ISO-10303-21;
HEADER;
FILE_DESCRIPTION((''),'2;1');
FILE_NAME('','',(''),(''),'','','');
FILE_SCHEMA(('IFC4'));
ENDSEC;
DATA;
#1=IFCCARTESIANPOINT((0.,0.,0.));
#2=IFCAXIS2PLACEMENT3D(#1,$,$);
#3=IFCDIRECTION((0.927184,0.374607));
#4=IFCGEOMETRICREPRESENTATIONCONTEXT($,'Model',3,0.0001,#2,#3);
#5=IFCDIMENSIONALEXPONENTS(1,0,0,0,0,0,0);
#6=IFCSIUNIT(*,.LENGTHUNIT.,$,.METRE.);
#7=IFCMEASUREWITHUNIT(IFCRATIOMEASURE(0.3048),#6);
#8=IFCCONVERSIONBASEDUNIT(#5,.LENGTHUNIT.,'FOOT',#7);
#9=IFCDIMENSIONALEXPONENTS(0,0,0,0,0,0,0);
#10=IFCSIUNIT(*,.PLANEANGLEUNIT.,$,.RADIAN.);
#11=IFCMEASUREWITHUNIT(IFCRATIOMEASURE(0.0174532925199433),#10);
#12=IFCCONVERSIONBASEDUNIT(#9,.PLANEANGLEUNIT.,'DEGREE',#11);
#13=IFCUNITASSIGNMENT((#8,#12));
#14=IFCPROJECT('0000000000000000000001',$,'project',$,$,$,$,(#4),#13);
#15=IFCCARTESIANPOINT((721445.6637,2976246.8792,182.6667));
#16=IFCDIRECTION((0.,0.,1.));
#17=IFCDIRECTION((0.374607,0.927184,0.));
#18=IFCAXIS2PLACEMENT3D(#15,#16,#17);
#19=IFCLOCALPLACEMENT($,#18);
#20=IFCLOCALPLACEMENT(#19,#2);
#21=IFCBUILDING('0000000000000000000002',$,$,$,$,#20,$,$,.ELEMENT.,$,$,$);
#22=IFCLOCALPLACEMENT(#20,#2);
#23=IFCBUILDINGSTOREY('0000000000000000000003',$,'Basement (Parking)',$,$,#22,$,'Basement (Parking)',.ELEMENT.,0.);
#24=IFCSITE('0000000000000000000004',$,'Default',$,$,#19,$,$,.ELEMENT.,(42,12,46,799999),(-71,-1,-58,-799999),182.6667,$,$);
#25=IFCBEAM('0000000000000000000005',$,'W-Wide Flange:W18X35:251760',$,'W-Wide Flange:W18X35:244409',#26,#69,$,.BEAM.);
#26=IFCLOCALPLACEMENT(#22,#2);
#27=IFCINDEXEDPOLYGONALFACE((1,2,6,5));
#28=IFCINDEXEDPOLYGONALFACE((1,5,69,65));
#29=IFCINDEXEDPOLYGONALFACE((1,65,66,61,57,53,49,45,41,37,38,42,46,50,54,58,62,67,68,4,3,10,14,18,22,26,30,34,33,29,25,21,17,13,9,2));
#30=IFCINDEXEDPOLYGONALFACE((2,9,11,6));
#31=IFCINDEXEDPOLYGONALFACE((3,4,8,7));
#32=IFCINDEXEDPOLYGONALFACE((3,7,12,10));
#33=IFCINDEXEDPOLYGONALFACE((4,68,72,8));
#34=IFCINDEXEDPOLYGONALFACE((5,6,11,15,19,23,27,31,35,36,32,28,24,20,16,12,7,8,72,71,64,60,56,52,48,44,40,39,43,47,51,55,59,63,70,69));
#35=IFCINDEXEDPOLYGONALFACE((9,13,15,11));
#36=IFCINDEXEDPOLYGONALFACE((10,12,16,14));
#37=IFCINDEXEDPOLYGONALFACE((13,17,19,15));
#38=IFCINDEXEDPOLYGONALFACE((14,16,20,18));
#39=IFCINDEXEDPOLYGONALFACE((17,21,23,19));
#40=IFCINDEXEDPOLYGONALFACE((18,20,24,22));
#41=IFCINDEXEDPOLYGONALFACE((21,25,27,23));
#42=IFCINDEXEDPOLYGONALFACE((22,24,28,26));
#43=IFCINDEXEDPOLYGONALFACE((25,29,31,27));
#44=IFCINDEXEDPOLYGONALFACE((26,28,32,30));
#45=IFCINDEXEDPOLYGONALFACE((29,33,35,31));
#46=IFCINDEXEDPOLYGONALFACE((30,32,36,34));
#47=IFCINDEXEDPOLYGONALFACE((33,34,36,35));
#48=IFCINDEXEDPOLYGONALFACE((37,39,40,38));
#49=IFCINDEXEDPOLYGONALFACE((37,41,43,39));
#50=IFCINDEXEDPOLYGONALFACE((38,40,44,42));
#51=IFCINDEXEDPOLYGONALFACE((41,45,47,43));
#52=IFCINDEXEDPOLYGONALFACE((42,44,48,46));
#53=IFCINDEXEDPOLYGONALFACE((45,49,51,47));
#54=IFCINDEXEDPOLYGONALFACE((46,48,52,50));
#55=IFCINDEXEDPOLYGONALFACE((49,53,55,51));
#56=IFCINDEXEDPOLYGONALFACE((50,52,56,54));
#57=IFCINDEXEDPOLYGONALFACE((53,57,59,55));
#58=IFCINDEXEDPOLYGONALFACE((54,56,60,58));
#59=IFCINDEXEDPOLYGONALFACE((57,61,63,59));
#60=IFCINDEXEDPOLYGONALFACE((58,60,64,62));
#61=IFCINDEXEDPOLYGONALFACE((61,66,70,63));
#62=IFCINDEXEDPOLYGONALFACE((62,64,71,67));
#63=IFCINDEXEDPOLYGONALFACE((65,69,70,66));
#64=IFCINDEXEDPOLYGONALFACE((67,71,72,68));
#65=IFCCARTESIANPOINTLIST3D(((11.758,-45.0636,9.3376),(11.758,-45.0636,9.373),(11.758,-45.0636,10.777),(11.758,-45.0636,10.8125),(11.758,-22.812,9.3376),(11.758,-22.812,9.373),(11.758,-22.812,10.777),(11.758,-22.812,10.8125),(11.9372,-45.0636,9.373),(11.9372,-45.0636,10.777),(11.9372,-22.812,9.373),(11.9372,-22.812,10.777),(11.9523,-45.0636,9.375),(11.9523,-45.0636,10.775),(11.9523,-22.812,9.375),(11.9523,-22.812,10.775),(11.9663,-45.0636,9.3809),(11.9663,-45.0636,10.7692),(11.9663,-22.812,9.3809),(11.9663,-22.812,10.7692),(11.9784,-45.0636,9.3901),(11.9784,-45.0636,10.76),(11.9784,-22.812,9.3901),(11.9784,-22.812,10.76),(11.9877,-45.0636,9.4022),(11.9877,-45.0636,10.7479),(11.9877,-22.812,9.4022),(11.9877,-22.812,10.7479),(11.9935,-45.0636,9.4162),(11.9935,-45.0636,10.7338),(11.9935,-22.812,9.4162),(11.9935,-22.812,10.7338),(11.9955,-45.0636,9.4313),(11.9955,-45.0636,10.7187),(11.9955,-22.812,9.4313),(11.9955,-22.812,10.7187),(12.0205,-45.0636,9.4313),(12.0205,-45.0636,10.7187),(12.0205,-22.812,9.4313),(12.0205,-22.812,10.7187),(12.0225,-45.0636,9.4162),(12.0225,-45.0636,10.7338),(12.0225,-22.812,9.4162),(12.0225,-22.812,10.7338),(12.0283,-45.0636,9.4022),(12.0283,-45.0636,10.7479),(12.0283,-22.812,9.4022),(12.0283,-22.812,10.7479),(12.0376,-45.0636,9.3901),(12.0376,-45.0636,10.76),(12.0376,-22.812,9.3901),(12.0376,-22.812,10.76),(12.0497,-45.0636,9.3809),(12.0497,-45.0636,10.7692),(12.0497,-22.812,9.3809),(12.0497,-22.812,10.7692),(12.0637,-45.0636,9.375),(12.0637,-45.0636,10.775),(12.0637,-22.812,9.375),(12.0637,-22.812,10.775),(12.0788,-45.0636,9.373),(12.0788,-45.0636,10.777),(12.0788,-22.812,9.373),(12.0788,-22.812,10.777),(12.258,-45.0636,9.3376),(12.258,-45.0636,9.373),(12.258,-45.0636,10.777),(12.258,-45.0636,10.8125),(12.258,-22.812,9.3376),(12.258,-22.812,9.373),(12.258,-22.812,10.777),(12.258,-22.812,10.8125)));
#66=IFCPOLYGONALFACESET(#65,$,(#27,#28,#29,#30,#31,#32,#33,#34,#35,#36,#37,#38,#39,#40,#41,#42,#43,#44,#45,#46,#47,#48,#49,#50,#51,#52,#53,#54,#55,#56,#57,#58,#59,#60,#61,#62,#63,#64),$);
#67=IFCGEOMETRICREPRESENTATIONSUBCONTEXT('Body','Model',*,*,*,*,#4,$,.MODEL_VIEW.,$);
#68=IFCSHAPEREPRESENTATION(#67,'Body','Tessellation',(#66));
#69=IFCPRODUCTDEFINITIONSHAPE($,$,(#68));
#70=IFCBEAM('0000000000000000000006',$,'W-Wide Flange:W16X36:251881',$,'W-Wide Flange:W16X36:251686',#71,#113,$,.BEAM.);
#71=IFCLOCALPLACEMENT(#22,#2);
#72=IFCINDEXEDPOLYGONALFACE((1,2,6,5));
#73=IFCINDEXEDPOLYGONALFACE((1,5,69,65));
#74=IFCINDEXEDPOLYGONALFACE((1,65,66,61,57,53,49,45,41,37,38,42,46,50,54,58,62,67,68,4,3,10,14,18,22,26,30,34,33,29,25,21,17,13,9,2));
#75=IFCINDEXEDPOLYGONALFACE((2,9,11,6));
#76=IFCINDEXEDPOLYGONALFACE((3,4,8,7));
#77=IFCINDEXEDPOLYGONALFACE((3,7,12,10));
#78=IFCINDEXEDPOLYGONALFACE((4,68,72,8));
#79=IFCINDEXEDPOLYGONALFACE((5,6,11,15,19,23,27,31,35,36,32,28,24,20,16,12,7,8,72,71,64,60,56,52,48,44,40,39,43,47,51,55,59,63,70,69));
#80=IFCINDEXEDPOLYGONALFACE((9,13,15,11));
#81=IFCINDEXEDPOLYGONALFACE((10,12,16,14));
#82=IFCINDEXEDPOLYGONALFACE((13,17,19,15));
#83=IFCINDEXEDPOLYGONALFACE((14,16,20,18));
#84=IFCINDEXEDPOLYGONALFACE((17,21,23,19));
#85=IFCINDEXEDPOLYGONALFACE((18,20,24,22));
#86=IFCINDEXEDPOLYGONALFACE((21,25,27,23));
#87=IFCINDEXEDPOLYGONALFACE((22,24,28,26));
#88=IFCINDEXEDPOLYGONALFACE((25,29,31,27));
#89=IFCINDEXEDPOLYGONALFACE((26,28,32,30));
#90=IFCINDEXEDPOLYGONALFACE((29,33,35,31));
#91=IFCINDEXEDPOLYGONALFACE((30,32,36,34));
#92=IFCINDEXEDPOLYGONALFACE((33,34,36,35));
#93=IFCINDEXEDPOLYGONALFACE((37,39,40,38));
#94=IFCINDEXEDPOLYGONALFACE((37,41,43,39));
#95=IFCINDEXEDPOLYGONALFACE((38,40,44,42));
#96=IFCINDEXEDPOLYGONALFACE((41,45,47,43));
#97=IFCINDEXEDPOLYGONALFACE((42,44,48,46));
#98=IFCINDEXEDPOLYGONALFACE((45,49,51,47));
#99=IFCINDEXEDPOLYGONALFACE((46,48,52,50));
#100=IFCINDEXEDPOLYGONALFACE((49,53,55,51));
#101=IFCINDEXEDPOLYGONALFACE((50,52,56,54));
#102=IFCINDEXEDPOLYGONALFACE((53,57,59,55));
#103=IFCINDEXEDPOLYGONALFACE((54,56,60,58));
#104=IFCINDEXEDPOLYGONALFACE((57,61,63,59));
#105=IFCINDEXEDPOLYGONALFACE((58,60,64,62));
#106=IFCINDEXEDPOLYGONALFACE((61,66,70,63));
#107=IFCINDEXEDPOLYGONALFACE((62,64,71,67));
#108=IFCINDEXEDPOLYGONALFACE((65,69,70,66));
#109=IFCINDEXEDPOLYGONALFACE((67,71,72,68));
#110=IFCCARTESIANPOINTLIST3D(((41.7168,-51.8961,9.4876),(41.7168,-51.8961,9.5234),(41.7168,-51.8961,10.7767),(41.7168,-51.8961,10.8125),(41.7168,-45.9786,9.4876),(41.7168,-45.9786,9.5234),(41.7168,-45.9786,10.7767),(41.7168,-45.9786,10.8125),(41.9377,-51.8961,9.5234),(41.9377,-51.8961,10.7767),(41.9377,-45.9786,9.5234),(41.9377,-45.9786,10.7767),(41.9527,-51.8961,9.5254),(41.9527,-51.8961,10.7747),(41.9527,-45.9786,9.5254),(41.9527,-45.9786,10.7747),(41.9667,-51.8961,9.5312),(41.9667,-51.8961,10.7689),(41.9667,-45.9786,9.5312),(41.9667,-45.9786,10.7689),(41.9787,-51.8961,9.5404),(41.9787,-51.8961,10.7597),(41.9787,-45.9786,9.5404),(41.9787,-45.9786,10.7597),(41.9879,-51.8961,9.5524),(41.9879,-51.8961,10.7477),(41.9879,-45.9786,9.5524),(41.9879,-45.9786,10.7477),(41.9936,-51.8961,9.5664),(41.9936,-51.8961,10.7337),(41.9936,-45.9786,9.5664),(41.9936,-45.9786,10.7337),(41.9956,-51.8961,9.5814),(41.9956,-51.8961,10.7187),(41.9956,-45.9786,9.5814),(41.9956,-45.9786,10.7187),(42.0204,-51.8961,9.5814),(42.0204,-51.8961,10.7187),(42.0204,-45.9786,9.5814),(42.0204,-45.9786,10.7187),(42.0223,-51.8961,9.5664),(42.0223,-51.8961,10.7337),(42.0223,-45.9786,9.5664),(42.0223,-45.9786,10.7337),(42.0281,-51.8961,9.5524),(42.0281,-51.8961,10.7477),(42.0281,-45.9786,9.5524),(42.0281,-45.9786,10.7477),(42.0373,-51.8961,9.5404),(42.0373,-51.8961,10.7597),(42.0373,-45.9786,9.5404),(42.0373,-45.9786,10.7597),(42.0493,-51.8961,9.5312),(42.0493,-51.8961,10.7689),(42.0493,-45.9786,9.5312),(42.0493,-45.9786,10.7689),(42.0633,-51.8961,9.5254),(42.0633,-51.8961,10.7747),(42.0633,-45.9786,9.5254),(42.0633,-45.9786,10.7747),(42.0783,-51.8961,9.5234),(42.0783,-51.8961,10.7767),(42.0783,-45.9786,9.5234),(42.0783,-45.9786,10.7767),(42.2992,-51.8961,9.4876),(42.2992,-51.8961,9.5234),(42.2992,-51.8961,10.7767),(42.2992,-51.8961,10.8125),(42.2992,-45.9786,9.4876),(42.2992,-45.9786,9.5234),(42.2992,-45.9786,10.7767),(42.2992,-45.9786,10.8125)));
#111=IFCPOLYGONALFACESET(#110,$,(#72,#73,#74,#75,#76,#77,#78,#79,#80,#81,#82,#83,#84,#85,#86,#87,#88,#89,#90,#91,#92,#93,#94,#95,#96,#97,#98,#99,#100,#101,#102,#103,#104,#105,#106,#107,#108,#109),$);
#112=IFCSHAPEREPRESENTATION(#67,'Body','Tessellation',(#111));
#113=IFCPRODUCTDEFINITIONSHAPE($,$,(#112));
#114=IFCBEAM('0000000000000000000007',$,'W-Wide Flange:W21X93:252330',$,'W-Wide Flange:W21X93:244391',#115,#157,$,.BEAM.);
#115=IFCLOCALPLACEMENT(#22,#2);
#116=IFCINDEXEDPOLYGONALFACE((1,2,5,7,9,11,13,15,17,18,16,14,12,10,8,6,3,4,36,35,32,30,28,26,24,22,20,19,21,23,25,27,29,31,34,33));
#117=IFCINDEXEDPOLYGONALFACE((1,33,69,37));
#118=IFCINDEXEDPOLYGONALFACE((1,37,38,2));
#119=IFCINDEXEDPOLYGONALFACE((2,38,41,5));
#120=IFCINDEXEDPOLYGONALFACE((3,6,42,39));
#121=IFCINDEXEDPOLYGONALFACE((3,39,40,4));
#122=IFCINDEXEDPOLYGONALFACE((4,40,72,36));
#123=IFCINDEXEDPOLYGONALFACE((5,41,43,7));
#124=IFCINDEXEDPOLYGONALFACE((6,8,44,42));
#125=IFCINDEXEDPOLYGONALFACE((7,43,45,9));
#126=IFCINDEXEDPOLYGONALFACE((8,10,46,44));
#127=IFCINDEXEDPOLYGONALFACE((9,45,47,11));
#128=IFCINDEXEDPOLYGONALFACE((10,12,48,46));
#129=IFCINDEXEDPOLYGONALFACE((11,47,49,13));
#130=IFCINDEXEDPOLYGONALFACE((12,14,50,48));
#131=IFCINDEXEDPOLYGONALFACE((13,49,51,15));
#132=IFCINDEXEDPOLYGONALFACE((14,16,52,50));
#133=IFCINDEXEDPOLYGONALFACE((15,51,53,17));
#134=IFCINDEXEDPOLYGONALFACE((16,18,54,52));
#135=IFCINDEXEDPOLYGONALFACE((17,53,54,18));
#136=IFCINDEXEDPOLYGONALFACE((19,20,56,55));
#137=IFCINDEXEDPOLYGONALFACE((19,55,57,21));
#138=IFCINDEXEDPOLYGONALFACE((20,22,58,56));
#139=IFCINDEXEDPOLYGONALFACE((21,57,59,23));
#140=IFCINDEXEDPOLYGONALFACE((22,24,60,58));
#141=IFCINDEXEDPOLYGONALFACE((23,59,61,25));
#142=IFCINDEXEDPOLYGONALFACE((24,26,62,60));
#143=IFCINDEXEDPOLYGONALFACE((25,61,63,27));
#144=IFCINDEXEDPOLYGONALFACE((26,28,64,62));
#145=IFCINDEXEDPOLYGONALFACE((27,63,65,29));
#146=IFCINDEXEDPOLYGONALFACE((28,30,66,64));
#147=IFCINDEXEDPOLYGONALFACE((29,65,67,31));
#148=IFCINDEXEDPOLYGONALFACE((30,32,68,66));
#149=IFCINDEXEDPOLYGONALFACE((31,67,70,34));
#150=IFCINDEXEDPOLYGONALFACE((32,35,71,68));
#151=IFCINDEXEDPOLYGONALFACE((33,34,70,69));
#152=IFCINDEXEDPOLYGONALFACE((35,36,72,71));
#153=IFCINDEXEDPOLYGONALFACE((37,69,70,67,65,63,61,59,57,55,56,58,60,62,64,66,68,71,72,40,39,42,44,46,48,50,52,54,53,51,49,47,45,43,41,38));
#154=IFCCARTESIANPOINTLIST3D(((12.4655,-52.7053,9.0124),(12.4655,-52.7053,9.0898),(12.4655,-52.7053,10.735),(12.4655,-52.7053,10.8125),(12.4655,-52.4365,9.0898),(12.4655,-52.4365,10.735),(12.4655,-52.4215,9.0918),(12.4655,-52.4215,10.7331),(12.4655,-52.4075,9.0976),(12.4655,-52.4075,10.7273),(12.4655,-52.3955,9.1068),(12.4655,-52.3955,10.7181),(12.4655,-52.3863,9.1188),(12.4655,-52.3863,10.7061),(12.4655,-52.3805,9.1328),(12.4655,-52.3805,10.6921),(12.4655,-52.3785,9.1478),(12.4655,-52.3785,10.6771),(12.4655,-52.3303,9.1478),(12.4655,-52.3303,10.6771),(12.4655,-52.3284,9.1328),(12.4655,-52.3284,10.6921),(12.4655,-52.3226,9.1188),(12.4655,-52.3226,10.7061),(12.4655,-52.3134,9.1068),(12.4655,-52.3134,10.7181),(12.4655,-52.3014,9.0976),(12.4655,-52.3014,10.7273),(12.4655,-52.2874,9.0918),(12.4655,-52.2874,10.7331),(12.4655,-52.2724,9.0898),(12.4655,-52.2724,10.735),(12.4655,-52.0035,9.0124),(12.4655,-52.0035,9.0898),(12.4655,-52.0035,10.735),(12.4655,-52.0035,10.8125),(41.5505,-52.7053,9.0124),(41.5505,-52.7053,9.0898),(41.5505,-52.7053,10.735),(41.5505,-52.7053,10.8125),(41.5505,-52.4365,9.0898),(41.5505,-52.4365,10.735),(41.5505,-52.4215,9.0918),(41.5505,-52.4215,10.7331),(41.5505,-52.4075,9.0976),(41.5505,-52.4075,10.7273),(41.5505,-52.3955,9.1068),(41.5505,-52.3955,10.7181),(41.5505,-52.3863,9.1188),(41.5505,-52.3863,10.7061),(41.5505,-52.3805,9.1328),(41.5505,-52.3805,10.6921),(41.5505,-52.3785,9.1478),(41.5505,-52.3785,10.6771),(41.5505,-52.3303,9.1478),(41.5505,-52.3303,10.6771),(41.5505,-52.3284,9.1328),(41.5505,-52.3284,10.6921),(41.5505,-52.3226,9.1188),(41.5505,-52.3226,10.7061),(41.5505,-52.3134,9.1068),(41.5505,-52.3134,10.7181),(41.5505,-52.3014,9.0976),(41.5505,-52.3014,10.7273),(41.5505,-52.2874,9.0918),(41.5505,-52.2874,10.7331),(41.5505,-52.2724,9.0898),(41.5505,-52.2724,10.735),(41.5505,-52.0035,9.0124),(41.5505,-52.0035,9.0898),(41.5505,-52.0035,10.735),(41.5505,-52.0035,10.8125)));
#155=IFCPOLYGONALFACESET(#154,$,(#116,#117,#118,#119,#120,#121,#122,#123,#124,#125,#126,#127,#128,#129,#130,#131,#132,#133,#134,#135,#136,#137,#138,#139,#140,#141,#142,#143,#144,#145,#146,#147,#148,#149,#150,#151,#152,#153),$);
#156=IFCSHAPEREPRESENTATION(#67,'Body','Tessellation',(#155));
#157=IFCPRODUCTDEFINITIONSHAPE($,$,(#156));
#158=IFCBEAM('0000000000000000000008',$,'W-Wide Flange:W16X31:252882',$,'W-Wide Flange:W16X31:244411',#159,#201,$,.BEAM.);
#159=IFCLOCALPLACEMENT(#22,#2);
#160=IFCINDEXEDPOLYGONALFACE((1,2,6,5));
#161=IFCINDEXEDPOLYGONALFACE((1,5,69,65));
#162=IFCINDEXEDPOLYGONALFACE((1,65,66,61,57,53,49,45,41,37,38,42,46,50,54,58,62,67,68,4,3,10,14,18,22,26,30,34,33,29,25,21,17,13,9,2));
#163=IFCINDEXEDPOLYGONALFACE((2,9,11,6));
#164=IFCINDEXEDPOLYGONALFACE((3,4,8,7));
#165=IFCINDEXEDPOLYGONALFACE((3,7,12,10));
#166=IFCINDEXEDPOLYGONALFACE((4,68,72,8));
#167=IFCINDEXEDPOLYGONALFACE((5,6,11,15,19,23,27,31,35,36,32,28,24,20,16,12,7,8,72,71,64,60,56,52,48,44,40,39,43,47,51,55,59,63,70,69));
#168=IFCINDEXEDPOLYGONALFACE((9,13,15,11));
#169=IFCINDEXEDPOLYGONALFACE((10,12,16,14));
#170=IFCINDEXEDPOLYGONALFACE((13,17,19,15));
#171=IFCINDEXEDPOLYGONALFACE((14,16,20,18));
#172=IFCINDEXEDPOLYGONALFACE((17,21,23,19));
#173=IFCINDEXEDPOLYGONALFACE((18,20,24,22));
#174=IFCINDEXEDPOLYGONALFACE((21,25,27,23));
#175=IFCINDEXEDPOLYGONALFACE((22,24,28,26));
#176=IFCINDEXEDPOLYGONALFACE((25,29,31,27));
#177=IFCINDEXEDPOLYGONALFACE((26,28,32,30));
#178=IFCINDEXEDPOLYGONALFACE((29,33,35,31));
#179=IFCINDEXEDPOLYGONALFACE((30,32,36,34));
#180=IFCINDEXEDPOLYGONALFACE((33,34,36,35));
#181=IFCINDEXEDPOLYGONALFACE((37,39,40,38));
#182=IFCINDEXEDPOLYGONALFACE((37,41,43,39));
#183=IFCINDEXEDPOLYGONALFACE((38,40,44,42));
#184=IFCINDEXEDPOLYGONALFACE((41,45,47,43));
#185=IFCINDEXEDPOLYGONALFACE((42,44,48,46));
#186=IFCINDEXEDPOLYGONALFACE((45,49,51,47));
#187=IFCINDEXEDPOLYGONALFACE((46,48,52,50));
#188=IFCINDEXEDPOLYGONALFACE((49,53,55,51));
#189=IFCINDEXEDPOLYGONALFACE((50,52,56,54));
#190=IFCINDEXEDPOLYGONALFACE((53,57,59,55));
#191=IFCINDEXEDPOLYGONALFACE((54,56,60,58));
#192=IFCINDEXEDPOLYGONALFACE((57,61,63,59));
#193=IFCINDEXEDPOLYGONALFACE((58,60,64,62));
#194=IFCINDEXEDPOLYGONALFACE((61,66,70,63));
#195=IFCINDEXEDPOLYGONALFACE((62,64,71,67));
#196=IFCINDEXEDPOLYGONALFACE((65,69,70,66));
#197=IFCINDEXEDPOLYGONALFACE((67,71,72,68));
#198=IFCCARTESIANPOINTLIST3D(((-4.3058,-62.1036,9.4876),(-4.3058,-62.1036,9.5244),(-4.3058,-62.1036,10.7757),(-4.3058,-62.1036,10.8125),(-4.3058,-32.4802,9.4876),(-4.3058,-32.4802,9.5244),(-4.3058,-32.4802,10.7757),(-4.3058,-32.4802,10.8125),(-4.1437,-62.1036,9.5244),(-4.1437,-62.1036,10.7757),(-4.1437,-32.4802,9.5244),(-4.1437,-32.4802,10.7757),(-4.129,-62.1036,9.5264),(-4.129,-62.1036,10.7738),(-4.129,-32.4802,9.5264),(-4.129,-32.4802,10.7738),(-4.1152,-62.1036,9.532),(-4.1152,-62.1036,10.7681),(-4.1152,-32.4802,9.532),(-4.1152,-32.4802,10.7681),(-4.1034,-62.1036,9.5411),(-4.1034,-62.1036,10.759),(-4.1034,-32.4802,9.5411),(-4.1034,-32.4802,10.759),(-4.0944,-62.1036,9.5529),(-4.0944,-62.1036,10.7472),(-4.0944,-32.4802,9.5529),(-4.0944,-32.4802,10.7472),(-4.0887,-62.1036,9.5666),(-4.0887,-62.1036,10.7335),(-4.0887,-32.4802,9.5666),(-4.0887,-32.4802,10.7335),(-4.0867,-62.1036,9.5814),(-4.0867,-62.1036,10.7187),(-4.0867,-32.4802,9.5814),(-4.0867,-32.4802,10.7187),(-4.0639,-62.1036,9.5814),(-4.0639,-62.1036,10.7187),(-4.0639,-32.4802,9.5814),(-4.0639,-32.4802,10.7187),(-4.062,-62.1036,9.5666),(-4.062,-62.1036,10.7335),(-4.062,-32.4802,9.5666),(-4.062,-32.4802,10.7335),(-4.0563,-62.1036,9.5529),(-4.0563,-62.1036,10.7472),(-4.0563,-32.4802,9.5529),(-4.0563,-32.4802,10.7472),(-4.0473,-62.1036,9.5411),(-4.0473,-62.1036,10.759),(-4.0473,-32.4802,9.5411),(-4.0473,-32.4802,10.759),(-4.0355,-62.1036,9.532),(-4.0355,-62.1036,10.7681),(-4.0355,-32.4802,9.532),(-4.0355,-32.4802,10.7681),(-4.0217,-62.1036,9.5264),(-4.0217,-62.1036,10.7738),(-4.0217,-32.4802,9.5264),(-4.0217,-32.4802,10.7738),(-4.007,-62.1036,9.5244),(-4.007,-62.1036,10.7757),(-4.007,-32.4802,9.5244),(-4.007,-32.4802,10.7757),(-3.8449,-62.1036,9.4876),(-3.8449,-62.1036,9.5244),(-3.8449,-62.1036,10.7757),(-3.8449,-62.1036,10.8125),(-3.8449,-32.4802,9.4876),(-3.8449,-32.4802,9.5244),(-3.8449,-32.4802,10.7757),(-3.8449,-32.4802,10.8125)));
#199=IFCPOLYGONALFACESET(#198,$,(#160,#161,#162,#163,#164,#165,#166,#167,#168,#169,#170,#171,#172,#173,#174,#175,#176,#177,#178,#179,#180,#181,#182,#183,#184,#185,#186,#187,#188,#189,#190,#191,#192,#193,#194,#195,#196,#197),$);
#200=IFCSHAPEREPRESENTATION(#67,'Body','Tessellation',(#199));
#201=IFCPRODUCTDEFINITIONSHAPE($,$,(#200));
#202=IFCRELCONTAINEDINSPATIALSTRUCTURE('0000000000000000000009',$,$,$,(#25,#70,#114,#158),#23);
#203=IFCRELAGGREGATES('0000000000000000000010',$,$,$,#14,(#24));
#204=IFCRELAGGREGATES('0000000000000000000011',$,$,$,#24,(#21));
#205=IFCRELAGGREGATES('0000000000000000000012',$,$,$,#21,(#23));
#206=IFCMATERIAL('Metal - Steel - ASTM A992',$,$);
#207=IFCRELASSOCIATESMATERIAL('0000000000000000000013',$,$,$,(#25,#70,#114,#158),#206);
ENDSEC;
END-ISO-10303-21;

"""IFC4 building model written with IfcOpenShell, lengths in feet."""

from ifc_helpers import new_model, entity, si_unit, converted_unit, direction, frame, frame_2d, origin, place, context, subcontext, project, spatial, i_section, extrude, material, element, save


model = new_model("IFC4")

# Units and contexts
model_context = context("Model", 3, precision=0.0001, world=origin(), true_north=direction((0.927184, 0.374607)))
body_context = subcontext(model_context, "Body", "Model", "MODEL_VIEW")
ifc_project = project(units=[converted_unit("LENGTHUNIT", "FOOT", entity("IfcRatioMeasure", 0.3048), si_unit("LENGTHUNIT", "METRE"), dimensions=[1, 0, 0, 0, 0, 0, 0]), converted_unit("PLANEANGLEUNIT", "DEGREE", entity("IfcRatioMeasure", 0.0174532925199433), si_unit("PLANEANGLEUNIT", "RADIAN"), dimensions=[0, 0, 0, 0, 0, 0, 0])], contexts=[model_context])

# Site, building, storey
site_placement = place(None, frame((721445.6637, 2976246.8792, 182.6667), z_axis=(0.0, 0.0, 1.0), x_axis=(0.374607, 0.927184, 0.0)))
site = spatial("IfcSite", under=ifc_project, at=site_placement, Name="Default", CompositionType="ELEMENT", RefLatitude=(42, 12, 46, 799999), RefLongitude=(-71, -1, -58, -799999), RefElevation=182.6667)
building_placement = place(site_placement, origin())
building = spatial("IfcBuilding", under=site, at=building_placement, CompositionType="ELEMENT")
storey_placement = place(building_placement, origin())
storey = spatial("IfcBuildingStorey", under=building, at=storey_placement, Name="Basement (Parking)", LongName="Basement (Parking)", CompositionType="ELEMENT", Elevation=0.0)

# Shared definitions
ifc_material_1 = material(Name="Metal - Steel - ASTM A992")

# Beams
beam_1_placement = place(storey_placement, frame((12.008, -45.5211, 10.8125), z_axis=(0.0, 0.0, 1.0), x_axis=(0.0, 1.0, 0.0)))
element("IfcBeam", 1, at=beam_1_placement, inside=storey, material=ifc_material_1, Name="W-Wide Flange:W18X35:251760", ObjectType="W-Wide Flange:W18X35:244409", PredefinedType="BEAM", context=body_context, shape_type="SweptSolid", body=[
    extrude(i_section(OverallWidth=0.5, OverallDepth=1.4749, WebThickness=0.0251, FlangeThickness=0.0355, FilletRadius=0.0583, at=frame_2d((0.0, 0.0), x_axis=(0.0, 1.0))), frame((0.4575, 0.0, -0.7375), z_axis=(1.0, 0.0, 0.0), x_axis=(0.0, 0.0, -1.0)), (0.0, 0.0, 1.0), 22.2516),
])
beam_2_placement = place(storey_placement, frame((42.008, -45.5211, 10.8125), z_axis=(0.0, 0.0, 1.0), x_axis=(0.0, -1.0, 0.0)))
element("IfcBeam", 2, at=beam_2_placement, inside=storey, material=ifc_material_1, Name="W-Wide Flange:W16X36:251881", ObjectType="W-Wide Flange:W16X36:251686", PredefinedType="BEAM", context=body_context, shape_type="SweptSolid", body=[
    extrude(i_section(OverallWidth=0.5824, OverallDepth=1.3249, WebThickness=0.0247, FlangeThickness=0.0358, FilletRadius=0.0579, at=frame_2d((0.0, 0.0), x_axis=(0.0, 1.0))), frame((0.4575, 0.0, -0.6624), z_axis=(1.0, 0.0, 0.0), x_axis=(0.0, 0.0, -1.0)), (0.0, 0.0, 1.0), 5.9175),
])
beam_3_placement = place(storey_placement, frame((12.008, -52.3544, 10.8125)))
element("IfcBeam", 3, at=beam_3_placement, inside=storey, material=ifc_material_1, Name="W-Wide Flange:W21X93:252330", ObjectType="W-Wide Flange:W21X93:244391", PredefinedType="BEAM", context=body_context, shape_type="SweptSolid", body=[
    extrude(i_section(OverallWidth=0.7018, OverallDepth=1.8001, WebThickness=0.0482, FlangeThickness=0.0775, FilletRadius=0.0579, at=frame_2d((0.0, 0.0), x_axis=(0.0, 1.0))), frame((0.4575, 0.0, -0.9001), z_axis=(1.0, 0.0, 0.0), x_axis=(0.0, 0.0, -1.0)), (0.0, 0.0, 1.0), 29.085),
])
beam_4_placement = place(storey_placement, frame((-4.0753, -62.3961, 10.8125), z_axis=(0.0, 0.0, 1.0), x_axis=(0.0, 1.0, 0.0)))
element("IfcBeam", 4, at=beam_4_placement, inside=storey, material=ifc_material_1, Name="W-Wide Flange:W16X31:252882", ObjectType="W-Wide Flange:W16X31:244411", PredefinedType="BEAM", context=body_context, shape_type="SweptSolid", body=[
    extrude(i_section(OverallWidth=0.4609, OverallDepth=1.3249, WebThickness=0.0228, FlangeThickness=0.0368, FilletRadius=0.057, at=frame_2d((0.0, 0.0), x_axis=(0.0, 1.0))), frame((0.2925, 0.0, -0.6624), z_axis=(1.0, 0.0, 0.0), x_axis=(0.0, 0.0, -1.0)), (0.0, 0.0, 1.0), 29.6234),
])

save(model, "model.ifc")
